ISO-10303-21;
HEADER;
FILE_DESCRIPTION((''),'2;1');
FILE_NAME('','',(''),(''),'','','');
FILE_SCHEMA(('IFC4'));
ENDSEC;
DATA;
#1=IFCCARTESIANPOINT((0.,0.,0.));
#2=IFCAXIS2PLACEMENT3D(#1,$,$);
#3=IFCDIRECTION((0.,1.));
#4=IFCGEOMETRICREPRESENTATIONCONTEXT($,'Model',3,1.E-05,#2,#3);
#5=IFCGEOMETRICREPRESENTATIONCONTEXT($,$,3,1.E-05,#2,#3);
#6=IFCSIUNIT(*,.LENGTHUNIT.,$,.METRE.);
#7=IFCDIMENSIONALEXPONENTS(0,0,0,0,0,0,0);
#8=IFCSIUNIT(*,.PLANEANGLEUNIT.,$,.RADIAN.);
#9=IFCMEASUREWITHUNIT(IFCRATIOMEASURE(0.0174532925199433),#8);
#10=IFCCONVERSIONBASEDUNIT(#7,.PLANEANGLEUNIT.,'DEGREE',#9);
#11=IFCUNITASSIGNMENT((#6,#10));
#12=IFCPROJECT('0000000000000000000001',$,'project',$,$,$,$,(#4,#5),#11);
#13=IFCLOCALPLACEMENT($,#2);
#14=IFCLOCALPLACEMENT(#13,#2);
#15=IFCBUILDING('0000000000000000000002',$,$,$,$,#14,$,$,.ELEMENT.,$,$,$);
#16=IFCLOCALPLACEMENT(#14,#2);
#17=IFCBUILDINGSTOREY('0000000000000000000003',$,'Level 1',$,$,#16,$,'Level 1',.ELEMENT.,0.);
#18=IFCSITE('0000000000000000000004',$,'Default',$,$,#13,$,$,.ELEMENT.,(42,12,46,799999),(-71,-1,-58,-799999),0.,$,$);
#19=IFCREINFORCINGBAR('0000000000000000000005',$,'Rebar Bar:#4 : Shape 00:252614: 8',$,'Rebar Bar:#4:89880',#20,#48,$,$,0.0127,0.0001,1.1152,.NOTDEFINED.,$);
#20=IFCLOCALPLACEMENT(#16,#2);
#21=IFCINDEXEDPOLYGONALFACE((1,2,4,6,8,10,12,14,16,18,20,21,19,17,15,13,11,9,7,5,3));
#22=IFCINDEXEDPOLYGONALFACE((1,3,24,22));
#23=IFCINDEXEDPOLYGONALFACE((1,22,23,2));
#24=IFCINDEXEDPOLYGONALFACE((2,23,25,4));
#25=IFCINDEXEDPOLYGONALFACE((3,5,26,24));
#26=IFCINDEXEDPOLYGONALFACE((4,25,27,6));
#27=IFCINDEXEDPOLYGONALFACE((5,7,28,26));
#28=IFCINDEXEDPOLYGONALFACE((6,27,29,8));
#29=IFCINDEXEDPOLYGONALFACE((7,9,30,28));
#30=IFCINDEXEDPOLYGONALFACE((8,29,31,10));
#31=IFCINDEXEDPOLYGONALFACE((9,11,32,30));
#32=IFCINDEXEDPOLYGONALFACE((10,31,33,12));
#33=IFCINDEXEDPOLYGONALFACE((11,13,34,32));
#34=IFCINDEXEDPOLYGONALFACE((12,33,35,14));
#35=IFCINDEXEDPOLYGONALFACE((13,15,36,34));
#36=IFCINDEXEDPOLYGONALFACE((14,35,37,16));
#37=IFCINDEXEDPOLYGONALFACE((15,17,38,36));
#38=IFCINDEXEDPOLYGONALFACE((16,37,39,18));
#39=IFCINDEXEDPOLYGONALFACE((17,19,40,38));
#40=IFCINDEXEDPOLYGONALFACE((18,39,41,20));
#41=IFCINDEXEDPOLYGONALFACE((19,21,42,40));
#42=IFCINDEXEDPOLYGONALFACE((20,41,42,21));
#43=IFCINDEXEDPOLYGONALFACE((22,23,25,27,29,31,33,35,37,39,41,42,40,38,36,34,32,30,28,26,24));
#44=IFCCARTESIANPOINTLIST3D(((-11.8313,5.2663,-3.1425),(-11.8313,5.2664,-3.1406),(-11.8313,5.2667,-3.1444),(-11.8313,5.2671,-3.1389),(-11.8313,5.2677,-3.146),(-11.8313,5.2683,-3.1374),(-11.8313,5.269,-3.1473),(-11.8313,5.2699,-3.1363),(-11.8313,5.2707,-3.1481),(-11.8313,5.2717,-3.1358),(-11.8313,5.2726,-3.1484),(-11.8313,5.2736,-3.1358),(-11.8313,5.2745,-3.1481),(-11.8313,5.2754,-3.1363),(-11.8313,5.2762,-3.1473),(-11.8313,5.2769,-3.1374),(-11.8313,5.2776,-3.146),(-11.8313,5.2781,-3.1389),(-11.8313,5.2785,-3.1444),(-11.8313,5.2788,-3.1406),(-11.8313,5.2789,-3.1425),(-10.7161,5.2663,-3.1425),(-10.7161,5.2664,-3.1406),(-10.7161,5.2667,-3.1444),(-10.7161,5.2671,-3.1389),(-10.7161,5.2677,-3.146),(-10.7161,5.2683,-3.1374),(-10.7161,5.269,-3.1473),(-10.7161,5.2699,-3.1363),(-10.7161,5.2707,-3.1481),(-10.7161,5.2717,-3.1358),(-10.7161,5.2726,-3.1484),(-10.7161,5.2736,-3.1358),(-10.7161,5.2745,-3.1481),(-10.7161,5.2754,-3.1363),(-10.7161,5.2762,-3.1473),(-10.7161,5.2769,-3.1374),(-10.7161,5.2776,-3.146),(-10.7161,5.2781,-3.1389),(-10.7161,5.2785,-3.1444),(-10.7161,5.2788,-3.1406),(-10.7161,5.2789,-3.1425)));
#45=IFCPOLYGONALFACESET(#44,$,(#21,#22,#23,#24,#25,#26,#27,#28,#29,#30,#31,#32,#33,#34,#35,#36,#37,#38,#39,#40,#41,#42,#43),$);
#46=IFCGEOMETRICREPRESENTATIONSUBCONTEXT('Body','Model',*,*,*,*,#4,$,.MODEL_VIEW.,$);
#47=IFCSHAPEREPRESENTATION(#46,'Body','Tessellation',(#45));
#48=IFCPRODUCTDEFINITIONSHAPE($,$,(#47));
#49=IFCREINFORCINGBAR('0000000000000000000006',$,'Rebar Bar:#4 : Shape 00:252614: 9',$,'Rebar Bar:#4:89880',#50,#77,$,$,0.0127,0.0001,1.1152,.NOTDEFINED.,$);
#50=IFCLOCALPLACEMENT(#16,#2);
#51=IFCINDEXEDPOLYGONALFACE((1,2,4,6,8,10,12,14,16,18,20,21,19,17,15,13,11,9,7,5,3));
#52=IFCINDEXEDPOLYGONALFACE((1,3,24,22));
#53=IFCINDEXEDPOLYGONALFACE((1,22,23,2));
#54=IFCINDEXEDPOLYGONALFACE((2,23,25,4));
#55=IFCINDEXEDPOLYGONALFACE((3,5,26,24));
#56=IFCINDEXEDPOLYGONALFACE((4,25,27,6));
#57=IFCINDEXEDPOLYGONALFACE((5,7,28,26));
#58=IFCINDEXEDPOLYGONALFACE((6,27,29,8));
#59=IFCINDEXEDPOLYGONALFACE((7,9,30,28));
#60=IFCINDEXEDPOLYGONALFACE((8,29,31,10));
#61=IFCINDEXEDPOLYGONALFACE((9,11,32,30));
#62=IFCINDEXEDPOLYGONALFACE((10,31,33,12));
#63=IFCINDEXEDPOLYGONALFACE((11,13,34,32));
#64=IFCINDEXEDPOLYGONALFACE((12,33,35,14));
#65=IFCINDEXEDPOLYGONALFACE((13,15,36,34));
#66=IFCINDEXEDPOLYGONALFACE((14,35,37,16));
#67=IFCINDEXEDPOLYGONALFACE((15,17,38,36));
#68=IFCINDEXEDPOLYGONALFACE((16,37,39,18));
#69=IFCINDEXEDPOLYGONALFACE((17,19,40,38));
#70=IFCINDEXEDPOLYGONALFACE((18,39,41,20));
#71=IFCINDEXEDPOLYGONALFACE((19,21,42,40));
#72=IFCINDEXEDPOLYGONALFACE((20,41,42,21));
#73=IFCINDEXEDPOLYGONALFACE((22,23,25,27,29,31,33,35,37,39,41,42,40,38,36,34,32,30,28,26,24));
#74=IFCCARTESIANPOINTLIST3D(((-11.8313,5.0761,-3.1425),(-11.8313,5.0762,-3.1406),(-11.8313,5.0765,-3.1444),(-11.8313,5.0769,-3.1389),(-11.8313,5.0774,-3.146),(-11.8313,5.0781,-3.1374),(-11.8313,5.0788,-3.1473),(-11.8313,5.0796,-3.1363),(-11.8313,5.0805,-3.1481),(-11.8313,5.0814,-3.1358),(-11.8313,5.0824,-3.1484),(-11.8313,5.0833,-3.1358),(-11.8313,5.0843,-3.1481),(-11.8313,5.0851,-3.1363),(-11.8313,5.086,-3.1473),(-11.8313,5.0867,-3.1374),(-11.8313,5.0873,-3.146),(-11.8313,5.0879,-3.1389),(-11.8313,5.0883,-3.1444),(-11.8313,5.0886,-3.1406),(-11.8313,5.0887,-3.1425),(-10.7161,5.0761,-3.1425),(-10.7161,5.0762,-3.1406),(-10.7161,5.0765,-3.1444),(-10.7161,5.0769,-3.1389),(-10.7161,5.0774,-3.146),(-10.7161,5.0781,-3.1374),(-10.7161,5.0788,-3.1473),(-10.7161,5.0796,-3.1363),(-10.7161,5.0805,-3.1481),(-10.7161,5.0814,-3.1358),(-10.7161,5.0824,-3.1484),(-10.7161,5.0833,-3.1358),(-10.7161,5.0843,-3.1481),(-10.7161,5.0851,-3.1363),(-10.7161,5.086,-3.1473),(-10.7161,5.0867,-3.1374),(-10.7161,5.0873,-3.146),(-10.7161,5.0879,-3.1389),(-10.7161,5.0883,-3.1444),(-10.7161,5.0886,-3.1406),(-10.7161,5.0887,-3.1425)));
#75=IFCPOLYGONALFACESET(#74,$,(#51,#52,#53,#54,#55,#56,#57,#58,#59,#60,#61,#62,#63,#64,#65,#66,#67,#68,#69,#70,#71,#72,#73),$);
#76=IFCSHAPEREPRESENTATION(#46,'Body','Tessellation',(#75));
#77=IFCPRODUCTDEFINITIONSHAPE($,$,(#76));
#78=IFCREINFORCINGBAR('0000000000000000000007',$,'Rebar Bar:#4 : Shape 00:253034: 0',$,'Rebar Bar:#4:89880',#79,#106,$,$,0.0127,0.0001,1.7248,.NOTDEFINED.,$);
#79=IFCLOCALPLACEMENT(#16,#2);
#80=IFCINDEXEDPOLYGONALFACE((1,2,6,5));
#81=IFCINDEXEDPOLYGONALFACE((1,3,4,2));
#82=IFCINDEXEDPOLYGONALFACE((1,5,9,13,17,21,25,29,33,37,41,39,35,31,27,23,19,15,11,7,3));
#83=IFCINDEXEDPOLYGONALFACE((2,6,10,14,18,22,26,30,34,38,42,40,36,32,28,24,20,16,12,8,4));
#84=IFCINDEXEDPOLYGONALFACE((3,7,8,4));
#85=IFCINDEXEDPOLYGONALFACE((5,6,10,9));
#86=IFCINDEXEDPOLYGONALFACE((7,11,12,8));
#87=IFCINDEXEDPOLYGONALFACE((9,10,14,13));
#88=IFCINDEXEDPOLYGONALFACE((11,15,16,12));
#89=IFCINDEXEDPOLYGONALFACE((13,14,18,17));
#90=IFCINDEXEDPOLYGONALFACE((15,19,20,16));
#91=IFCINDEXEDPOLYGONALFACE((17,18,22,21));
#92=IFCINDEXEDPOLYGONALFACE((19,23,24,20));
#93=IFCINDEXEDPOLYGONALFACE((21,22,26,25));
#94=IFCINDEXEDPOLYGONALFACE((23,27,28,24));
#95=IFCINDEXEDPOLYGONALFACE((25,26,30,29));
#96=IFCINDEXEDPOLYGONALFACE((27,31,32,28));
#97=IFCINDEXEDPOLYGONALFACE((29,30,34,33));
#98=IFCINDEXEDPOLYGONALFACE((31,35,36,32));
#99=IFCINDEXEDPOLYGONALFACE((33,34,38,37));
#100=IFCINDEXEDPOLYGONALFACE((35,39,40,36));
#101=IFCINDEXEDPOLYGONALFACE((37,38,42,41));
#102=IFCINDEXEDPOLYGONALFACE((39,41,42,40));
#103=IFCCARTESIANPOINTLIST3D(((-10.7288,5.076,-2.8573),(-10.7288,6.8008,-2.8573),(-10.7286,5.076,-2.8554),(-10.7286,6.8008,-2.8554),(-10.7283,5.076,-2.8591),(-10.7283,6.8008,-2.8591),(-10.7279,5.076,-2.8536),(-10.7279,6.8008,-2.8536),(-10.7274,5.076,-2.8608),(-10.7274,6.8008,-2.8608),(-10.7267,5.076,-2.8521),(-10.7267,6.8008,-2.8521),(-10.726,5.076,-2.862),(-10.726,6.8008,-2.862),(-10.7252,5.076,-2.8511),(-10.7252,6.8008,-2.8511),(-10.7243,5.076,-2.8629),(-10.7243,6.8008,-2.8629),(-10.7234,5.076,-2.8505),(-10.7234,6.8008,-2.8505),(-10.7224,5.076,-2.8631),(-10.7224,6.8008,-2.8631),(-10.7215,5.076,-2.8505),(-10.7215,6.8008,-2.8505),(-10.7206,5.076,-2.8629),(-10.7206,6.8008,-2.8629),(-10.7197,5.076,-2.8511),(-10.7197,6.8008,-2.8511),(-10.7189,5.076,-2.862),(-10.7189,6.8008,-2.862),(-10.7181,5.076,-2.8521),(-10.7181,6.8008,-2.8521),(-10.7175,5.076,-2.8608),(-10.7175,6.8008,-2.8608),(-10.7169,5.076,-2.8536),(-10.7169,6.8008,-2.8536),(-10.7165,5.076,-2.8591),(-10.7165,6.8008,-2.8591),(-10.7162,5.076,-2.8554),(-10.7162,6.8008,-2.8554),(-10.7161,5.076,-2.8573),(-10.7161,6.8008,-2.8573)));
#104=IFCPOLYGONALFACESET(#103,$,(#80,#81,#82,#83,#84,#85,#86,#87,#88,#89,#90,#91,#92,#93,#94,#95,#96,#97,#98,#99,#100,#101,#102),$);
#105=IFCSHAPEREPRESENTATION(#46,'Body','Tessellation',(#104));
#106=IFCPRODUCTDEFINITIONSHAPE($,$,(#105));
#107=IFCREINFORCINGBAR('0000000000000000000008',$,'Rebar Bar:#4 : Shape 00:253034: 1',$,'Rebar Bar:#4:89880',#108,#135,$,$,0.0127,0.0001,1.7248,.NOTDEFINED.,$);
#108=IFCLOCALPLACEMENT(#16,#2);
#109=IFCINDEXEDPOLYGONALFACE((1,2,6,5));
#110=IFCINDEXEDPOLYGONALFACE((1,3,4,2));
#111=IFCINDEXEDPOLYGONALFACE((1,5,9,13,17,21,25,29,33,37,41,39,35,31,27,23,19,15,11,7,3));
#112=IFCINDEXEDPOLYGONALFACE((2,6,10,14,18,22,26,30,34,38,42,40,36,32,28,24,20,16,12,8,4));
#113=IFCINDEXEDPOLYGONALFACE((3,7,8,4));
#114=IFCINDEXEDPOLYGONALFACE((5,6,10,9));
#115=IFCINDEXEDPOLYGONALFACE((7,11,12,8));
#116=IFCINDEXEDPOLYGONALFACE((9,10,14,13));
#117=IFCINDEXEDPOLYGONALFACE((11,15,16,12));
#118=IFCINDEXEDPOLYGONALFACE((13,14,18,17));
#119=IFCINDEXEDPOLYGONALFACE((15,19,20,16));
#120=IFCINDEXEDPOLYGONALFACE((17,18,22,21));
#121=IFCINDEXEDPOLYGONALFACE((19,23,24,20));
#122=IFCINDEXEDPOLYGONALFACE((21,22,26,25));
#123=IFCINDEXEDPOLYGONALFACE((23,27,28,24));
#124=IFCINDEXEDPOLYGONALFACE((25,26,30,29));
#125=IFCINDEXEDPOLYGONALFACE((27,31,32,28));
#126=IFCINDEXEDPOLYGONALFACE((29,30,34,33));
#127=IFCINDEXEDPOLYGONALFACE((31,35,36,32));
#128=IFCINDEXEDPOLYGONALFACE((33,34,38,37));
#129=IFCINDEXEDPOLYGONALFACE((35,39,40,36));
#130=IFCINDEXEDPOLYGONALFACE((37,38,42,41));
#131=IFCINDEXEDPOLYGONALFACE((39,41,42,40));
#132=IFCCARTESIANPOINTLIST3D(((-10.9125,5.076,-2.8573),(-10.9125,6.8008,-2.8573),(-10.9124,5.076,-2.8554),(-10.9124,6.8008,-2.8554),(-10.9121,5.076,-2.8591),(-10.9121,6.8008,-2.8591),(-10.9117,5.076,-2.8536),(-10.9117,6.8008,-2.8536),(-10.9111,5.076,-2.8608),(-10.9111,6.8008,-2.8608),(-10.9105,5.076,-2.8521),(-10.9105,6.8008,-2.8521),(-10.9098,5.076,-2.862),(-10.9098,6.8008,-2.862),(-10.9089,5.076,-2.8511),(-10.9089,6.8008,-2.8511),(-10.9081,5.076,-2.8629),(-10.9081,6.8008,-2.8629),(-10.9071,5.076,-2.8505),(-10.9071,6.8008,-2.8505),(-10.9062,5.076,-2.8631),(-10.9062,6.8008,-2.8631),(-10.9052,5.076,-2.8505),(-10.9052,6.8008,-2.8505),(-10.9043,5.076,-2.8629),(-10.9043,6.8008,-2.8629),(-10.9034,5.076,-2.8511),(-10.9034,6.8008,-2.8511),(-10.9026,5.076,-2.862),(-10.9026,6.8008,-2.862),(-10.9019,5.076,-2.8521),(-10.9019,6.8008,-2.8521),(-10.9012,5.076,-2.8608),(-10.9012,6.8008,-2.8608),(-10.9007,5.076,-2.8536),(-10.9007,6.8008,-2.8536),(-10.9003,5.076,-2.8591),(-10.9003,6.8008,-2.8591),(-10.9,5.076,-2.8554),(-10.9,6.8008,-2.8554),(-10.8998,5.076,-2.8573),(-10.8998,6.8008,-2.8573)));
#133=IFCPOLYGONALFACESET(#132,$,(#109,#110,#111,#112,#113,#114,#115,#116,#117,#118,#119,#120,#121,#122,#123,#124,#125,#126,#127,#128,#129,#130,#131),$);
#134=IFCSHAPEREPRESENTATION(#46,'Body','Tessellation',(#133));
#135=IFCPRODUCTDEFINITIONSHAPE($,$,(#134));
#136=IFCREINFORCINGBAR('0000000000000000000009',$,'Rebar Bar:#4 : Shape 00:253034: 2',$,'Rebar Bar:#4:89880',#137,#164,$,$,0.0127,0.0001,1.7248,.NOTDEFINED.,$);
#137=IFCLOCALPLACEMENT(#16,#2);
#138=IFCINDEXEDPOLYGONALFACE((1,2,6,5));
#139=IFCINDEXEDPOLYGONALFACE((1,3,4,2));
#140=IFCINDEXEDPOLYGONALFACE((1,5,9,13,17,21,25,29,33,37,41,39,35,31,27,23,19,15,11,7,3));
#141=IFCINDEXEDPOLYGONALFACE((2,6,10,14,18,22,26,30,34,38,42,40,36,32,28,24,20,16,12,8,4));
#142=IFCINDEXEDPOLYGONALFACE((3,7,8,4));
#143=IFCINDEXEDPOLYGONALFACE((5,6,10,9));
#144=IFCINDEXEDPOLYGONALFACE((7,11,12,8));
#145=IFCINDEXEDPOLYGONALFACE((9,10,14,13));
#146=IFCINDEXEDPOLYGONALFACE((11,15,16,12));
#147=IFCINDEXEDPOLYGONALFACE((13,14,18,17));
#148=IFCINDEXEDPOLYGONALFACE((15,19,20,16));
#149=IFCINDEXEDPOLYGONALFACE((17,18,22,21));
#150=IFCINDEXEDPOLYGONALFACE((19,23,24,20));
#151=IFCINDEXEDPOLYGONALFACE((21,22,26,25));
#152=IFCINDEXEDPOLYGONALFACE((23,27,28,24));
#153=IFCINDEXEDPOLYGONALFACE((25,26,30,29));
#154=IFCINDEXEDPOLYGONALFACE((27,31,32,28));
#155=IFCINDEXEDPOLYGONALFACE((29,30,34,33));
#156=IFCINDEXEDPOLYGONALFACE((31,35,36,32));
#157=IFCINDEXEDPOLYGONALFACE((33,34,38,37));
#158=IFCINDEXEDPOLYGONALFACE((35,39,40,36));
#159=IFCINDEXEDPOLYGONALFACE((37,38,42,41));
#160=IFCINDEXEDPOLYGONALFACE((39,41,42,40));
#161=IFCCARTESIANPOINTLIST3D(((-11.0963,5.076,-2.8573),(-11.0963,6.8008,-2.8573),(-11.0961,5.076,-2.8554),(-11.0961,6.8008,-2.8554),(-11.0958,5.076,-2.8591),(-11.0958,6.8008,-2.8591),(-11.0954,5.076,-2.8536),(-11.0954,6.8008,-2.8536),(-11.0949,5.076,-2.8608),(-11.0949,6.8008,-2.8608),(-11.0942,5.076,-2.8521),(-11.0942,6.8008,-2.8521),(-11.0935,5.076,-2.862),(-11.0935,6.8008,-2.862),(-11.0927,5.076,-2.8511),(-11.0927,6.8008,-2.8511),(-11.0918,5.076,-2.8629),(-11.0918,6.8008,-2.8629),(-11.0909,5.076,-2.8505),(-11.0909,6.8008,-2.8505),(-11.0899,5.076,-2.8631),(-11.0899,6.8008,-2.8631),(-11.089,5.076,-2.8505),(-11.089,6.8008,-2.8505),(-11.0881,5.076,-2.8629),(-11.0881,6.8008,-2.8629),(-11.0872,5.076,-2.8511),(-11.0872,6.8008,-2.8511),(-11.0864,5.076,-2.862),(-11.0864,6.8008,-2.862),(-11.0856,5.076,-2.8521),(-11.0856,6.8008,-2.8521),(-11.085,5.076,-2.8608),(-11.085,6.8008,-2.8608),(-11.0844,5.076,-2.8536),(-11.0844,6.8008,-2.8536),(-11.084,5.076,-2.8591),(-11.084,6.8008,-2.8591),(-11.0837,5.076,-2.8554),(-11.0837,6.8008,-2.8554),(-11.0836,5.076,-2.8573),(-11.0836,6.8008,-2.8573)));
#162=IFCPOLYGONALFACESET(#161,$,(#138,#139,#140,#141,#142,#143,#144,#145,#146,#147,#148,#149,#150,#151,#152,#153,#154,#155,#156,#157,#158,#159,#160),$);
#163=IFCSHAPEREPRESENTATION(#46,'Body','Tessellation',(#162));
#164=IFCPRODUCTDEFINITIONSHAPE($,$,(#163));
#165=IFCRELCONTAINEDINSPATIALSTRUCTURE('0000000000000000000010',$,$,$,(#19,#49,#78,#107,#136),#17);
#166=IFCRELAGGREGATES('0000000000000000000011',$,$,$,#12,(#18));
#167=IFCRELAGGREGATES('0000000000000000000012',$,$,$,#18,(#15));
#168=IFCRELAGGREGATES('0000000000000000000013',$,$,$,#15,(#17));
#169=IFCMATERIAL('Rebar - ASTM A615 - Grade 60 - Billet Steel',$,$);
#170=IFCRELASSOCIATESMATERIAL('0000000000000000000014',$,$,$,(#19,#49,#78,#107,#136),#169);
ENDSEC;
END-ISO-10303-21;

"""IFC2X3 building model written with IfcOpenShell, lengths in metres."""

from ifc_helpers import new_model, entity, si_unit, converted_unit, direction, origin, place, context, subcontext, project, spatial, material, element, save


model = new_model("IFC2X3")

# Units and contexts
model_context = context("Model", 3, precision=1e-05, world=origin(), true_north=direction((0.0, 1.0)))
context_of_model = context(None, 3, precision=1e-05, world=origin(), true_north=direction((0.0, 1.0)))
body_context = subcontext(model_context, "Body", "Model", "MODEL_VIEW")
ifc_project = project(units=[si_unit("LENGTHUNIT", "METRE"), converted_unit("PLANEANGLEUNIT", "DEGREE", entity("IfcRatioMeasure", 0.0174532925199433), si_unit("PLANEANGLEUNIT", "RADIAN"), dimensions=[0, 0, 0, 0, 0, 0, 0])], contexts=[model_context, context_of_model])

# Site, building, storey
site_placement = place(None, origin())
site = spatial("IfcSite", under=ifc_project, at=site_placement, Name="Default", CompositionType="ELEMENT", RefLatitude=(42, 12, 46, 799999), RefLongitude=(-71, -1, -58, -799999), RefElevation=0.0)
building_placement = place(site_placement, origin())
building = spatial("IfcBuilding", under=site, at=building_placement, CompositionType="ELEMENT")
storey_placement = place(building_placement, origin())
storey = spatial("IfcBuildingStorey", under=building, at=storey_placement, Name="Level 1", LongName="Level 1", CompositionType="ELEMENT", Elevation=0.0)

# Reinforcing bars
ifc_material = material(Name="Rebar - ASTM A615 - Grade 60 - Billet Steel")
reinforcing_bar_1_placement = place(storey_placement, origin())
element("IfcReinforcingBar", 1, at=reinforcing_bar_1_placement, inside=storey, material=ifc_material, Name="Rebar Bar:#4 : Shape 00:252614: 8", ObjectType="Rebar Bar:#4:89880", BarLength=1.1152, BarRole="NOTDEFINED", CrossSectionArea=0.0001, NominalDiameter=0.0127, context=body_context, shape_type="AdvancedSweptSolid", body=[
    entity("IfcSweptDiskSolid", entity("IfcCompositeCurve", [entity("IfcCompositeCurveSegment", "CONTINUOUS", True, entity("IfcPolyline", [entity("IfcCartesianPoint", [-10.7161, 5.2726, -3.142]), entity("IfcCartesianPoint", [-11.8313, 5.2726, -3.142])]))], False), 0.0063, None, 0.0, 1.0),
])
reinforcing_bar_2_placement = place(storey_placement, origin())
element("IfcReinforcingBar", 2, at=reinforcing_bar_2_placement, inside=storey, material=ifc_material, Name="Rebar Bar:#4 : Shape 00:252614: 9", ObjectType="Rebar Bar:#4:89880", BarLength=1.1152, BarRole="NOTDEFINED", CrossSectionArea=0.0001, NominalDiameter=0.0127, context=body_context, shape_type="AdvancedSweptSolid", body=[
    entity("IfcSweptDiskSolid", entity("IfcCompositeCurve", [entity("IfcCompositeCurveSegment", "CONTINUOUS", True, entity("IfcPolyline", [entity("IfcCartesianPoint", [-10.7161, 5.0824, -3.142]), entity("IfcCartesianPoint", [-11.8313, 5.0824, -3.142])]))], False), 0.0063, None, 0.0, 1.0),
])
reinforcing_bar_3_placement = place(storey_placement, origin())
element("IfcReinforcingBar", 3, at=reinforcing_bar_3_placement, inside=storey, material=ifc_material, Name="Rebar Bar:#4 : Shape 00:253034: 0", ObjectType="Rebar Bar:#4:89880", BarLength=1.7248, BarRole="NOTDEFINED", CrossSectionArea=0.0001, NominalDiameter=0.0127, context=body_context, shape_type="AdvancedSweptSolid", body=[
    entity("IfcSweptDiskSolid", entity("IfcCompositeCurve", [entity("IfcCompositeCurveSegment", "CONTINUOUS", True, entity("IfcPolyline", [entity("IfcCartesianPoint", [-10.7224, 6.8008, -2.8568]), entity("IfcCartesianPoint", [-10.7224, 5.076, -2.8568])]))], False), 0.0063, None, 0.0, 1.0),
])
reinforcing_bar_4_placement = place(storey_placement, origin())
element("IfcReinforcingBar", 4, at=reinforcing_bar_4_placement, inside=storey, material=ifc_material, Name="Rebar Bar:#4 : Shape 00:253034: 1", ObjectType="Rebar Bar:#4:89880", BarLength=1.7248, BarRole="NOTDEFINED", CrossSectionArea=0.0001, NominalDiameter=0.0127, context=body_context, shape_type="AdvancedSweptSolid", body=[
    entity("IfcSweptDiskSolid", entity("IfcCompositeCurve", [entity("IfcCompositeCurveSegment", "CONTINUOUS", True, entity("IfcPolyline", [entity("IfcCartesianPoint", [-10.9062, 6.8008, -2.8568]), entity("IfcCartesianPoint", [-10.9062, 5.076, -2.8568])]))], False), 0.0063, None, 0.0, 1.0),
])
reinforcing_bar_5_placement = place(storey_placement, origin())
element("IfcReinforcingBar", 5, at=reinforcing_bar_5_placement, inside=storey, material=ifc_material, Name="Rebar Bar:#4 : Shape 00:253034: 2", ObjectType="Rebar Bar:#4:89880", BarLength=1.7248, BarRole="NOTDEFINED", CrossSectionArea=0.0001, NominalDiameter=0.0127, context=body_context, shape_type="AdvancedSweptSolid", body=[
    entity("IfcSweptDiskSolid", entity("IfcCompositeCurve", [entity("IfcCompositeCurveSegment", "CONTINUOUS", True, entity("IfcPolyline", [entity("IfcCartesianPoint", [-11.0899, 6.8008, -2.8568]), entity("IfcCartesianPoint", [-11.0899, 5.076, -2.8568])]))], False), 0.0063, None, 0.0, 1.0),
])

save(model, "model.ifc")
